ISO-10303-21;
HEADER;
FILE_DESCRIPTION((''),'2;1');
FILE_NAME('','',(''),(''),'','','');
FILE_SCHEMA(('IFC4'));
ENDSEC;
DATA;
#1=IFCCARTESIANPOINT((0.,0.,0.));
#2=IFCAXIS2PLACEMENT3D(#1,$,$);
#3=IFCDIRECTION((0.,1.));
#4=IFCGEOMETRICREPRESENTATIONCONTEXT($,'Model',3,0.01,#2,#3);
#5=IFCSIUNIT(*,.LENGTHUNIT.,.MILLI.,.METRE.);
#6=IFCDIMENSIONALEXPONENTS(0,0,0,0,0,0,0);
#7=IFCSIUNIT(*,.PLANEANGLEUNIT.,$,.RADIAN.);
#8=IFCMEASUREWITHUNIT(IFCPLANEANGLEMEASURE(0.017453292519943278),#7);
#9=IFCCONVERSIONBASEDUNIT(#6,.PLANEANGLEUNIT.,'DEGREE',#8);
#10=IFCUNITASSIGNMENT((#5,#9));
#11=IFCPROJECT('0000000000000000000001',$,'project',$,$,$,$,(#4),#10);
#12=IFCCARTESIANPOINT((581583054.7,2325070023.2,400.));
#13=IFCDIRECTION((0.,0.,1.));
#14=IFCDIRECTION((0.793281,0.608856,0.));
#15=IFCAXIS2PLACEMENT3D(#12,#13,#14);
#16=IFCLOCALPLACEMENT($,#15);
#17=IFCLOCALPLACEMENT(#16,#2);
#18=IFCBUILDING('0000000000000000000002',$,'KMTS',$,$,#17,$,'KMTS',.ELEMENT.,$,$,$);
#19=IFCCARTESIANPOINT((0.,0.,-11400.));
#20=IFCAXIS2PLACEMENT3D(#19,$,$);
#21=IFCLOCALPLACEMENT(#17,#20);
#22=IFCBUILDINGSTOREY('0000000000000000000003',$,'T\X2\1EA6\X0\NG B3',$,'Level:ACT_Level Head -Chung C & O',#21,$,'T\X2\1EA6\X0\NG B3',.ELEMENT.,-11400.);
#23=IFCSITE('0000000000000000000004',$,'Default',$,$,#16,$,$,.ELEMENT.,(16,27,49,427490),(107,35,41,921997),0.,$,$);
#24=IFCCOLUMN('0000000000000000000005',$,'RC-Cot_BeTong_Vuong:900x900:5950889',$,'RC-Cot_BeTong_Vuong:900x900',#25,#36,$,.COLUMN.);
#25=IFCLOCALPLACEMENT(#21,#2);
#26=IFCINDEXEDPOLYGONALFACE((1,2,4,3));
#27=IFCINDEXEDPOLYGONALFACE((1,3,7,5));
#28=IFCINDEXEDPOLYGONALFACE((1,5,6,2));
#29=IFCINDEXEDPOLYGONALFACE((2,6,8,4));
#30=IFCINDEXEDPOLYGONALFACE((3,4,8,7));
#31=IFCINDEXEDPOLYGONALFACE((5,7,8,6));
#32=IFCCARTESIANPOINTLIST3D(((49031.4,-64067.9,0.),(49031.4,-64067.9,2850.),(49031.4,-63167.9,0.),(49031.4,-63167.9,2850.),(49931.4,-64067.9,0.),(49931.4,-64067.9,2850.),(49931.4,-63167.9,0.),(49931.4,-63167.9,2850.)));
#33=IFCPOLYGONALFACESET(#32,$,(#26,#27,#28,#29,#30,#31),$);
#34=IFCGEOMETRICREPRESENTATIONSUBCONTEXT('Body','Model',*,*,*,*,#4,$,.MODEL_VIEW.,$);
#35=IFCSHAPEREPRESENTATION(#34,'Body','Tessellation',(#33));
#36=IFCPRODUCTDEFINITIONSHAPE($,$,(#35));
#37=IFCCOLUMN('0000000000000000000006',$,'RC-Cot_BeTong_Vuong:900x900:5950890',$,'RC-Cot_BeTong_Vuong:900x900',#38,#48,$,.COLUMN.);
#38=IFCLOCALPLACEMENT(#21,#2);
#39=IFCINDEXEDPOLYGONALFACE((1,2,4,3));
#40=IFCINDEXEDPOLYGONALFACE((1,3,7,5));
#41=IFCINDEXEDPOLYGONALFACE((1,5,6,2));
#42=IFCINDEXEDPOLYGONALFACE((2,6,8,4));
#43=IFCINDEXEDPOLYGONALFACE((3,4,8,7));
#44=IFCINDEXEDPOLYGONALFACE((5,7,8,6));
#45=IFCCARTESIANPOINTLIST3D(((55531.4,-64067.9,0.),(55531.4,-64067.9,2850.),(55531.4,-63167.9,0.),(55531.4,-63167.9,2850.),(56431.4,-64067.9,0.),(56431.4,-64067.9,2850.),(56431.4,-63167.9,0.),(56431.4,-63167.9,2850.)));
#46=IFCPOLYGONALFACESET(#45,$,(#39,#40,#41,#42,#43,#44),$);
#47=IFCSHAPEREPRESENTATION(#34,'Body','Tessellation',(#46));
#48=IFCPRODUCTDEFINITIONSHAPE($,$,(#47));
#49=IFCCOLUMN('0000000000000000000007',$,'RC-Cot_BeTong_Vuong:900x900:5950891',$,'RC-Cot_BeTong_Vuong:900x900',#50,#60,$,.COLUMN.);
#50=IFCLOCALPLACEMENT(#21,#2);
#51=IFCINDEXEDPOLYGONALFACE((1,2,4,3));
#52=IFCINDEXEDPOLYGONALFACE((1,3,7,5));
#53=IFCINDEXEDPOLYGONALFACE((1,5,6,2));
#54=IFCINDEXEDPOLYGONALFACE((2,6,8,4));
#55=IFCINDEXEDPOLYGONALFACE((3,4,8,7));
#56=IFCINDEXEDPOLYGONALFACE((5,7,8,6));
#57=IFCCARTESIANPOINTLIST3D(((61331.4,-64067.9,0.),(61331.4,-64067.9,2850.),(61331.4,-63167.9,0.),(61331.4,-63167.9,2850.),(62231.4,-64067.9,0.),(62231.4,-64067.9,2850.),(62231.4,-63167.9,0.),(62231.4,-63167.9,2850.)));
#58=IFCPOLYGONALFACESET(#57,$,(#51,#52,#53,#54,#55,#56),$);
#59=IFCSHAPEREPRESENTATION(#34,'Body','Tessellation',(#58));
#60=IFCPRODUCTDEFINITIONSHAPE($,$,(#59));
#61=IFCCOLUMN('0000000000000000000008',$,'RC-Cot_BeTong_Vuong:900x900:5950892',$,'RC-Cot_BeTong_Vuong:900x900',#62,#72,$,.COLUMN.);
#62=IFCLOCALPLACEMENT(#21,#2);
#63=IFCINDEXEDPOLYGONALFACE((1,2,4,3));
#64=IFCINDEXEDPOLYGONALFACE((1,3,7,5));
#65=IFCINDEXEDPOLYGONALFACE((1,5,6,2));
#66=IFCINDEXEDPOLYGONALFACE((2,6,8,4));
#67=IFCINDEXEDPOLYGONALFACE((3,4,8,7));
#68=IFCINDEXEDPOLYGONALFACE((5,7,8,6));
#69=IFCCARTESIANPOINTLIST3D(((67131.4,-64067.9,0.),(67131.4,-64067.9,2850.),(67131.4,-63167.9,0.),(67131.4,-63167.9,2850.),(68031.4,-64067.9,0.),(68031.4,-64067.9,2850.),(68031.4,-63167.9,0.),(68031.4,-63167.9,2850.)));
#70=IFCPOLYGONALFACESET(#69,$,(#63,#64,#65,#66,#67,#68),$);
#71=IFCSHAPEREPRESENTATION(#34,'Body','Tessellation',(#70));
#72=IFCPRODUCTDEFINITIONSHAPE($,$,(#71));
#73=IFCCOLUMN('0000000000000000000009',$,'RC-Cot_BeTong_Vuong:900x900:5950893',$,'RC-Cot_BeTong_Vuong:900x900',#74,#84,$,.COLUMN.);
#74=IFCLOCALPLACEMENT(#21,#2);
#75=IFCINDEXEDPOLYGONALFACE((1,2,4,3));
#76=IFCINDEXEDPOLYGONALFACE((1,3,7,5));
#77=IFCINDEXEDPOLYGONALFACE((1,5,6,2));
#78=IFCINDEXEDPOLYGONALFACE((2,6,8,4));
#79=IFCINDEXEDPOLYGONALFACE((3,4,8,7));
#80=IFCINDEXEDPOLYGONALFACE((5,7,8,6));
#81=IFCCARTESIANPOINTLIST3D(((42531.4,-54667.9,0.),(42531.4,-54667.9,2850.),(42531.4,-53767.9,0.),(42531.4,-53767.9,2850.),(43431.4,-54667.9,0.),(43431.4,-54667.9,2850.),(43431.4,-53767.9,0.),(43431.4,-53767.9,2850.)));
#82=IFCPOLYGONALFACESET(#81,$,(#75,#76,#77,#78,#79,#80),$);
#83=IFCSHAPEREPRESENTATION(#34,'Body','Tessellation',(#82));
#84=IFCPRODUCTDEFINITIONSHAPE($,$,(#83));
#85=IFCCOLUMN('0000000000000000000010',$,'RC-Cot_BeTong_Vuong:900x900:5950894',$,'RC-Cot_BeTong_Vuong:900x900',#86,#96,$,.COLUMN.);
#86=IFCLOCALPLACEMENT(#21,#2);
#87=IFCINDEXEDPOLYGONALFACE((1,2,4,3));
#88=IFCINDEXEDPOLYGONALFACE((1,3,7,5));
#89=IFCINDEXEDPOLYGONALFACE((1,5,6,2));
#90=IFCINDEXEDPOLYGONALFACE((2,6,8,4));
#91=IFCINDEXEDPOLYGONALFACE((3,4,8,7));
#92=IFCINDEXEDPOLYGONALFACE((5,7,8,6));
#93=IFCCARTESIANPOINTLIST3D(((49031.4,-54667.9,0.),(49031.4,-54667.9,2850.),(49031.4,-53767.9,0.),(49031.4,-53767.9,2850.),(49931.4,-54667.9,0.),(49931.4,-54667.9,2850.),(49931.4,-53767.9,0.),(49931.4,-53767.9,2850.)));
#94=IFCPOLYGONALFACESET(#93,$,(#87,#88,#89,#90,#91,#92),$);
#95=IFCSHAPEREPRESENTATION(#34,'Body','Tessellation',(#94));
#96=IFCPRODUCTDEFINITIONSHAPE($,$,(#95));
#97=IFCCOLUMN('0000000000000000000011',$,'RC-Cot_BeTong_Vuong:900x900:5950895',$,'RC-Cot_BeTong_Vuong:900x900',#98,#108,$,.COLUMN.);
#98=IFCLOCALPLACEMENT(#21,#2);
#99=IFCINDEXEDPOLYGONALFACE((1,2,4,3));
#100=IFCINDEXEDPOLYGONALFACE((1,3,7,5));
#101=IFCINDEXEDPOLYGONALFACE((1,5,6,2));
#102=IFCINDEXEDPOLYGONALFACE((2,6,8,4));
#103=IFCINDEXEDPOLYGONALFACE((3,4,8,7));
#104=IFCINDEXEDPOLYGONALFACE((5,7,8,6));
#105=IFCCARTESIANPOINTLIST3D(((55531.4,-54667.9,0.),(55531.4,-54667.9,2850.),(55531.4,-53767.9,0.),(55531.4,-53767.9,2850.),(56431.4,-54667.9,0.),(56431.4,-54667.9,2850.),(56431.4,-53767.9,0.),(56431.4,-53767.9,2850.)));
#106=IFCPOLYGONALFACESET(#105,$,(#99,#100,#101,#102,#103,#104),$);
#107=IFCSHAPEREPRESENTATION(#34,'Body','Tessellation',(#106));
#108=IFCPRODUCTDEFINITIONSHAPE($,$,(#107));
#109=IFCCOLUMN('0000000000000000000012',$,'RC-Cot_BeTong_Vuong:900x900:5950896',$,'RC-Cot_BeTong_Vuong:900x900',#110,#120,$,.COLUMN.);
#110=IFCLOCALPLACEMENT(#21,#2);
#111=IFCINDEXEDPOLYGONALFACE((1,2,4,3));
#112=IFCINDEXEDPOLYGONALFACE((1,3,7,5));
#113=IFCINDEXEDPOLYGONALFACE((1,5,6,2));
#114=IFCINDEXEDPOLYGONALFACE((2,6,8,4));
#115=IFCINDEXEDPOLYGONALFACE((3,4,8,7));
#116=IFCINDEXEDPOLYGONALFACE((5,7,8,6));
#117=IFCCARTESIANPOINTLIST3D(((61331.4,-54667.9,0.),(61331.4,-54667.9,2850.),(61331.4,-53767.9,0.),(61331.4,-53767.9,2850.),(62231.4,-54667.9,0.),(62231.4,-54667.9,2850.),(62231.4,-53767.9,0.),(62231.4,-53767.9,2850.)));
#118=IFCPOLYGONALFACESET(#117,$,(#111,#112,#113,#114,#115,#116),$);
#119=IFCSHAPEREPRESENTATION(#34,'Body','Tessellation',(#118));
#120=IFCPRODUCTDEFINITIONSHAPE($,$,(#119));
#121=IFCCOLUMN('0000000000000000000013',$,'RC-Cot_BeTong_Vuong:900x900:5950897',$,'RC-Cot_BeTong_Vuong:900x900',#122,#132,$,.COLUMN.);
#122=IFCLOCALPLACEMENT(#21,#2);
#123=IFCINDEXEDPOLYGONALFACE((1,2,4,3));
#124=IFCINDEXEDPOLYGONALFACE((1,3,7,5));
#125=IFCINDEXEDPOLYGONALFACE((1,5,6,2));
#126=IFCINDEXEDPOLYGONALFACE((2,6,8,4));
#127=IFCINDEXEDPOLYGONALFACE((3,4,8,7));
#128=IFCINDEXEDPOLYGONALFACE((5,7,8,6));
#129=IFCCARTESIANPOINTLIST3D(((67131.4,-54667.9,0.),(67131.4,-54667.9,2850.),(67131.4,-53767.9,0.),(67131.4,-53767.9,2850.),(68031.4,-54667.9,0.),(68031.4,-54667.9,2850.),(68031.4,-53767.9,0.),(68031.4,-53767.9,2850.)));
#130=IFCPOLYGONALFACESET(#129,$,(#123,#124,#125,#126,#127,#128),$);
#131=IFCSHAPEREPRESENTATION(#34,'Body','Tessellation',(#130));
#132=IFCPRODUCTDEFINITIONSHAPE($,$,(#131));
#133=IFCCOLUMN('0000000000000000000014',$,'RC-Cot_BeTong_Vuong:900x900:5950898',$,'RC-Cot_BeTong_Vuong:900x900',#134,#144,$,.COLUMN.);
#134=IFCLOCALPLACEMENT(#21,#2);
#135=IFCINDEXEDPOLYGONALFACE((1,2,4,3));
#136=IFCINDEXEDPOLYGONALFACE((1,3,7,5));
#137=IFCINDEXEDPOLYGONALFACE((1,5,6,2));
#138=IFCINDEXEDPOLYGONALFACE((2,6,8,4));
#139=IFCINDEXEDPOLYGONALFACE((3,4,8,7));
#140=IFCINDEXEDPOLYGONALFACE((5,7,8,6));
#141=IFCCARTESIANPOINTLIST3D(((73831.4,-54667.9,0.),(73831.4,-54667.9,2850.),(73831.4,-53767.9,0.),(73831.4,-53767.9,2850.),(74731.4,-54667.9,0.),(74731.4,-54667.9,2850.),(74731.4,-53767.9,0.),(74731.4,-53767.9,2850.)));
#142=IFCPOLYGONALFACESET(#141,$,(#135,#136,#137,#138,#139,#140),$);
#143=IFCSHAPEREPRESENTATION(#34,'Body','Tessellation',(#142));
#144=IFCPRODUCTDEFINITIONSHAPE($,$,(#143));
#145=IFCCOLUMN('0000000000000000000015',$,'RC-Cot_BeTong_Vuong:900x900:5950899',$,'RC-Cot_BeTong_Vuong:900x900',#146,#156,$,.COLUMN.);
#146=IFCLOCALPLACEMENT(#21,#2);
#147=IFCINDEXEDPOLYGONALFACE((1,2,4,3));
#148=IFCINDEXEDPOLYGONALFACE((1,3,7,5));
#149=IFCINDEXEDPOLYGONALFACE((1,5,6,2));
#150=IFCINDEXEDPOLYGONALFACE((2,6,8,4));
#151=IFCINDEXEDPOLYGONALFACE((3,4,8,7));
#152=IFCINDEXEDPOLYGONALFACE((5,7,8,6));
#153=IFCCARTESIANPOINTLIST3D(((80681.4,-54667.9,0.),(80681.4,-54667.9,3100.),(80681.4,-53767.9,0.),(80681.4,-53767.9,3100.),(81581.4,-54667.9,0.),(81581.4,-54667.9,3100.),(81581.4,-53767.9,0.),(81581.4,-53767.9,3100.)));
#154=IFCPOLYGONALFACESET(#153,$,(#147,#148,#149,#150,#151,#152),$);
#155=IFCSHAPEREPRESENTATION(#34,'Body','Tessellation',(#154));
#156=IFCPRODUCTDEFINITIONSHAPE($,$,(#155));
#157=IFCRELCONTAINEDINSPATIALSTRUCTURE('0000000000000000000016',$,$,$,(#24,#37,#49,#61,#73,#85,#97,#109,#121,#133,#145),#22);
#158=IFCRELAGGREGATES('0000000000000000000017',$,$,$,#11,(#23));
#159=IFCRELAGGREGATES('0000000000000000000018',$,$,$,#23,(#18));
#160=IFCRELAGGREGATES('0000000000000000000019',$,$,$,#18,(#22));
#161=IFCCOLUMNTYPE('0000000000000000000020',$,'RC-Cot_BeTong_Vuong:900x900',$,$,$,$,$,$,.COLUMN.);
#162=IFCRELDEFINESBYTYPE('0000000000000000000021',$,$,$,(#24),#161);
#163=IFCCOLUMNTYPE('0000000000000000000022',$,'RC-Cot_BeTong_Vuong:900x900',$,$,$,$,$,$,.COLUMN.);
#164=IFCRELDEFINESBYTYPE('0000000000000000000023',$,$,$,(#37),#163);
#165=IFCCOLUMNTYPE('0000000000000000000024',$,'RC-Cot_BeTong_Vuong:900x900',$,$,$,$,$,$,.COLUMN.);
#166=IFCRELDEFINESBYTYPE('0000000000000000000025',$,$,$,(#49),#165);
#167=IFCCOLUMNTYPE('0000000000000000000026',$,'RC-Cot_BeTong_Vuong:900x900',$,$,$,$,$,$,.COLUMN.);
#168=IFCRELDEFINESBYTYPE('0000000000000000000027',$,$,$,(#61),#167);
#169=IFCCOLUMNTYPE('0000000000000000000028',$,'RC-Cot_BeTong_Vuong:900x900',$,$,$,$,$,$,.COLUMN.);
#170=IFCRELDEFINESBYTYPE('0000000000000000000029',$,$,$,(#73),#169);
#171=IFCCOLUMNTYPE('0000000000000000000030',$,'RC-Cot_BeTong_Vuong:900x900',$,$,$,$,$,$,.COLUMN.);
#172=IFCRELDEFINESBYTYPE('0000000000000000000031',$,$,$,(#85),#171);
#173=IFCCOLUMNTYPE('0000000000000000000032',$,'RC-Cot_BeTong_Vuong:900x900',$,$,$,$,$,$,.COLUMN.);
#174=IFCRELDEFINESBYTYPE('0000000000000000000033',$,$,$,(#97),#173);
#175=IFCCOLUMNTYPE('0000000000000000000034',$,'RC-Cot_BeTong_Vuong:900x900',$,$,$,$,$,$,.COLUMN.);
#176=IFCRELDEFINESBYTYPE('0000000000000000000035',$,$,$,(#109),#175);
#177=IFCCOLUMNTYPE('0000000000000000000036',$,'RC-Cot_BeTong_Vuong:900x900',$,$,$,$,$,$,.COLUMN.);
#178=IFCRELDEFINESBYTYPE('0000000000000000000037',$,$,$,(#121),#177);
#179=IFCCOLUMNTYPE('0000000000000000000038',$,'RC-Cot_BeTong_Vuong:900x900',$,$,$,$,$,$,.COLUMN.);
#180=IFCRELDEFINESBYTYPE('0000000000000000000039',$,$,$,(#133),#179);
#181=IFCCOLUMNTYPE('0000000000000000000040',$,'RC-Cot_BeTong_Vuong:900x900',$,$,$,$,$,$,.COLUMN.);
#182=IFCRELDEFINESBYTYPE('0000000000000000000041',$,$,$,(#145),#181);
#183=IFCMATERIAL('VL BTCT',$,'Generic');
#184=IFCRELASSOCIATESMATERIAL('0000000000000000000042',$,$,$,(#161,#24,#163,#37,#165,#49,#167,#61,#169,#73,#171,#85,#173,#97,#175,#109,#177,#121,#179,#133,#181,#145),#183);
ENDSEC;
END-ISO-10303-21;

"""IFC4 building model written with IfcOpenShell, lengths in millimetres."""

from ifc_helpers import new_model, entity, si_unit, converted_unit, direction, frame, origin, place, context, subcontext, project, spatial, indexed_curve, outline, extrude, source, transform, mapped, material, type_object, type_shapes, element, save


model = new_model("IFC4")

# Units and contexts
model_context = context("Model", 3, precision=0.01, world=origin(), true_north=direction((0.0, 1.0)))
body_context = subcontext(model_context, "Body", "Model", "MODEL_VIEW")
ifc_project = project(units=[si_unit("LENGTHUNIT", "METRE", prefix="MILLI"), converted_unit("PLANEANGLEUNIT", "DEGREE", entity("IfcPlaneAngleMeasure", 0.017453292519943278), si_unit("PLANEANGLEUNIT", "RADIAN"), dimensions=[0, 0, 0, 0, 0, 0, 0])], contexts=[model_context])

# Site, building, storey
site_placement = place(None, frame((581583054.7, 2325070023.2, 400.0), z_axis=(0.0, 0.0, 1.0), x_axis=(0.793281, 0.608856, 0.0)))
site = spatial("IfcSite", under=ifc_project, at=site_placement, Name="Default", CompositionType="ELEMENT", RefLatitude=(16, 27, 49, 427490), RefLongitude=(107, 35, 41, 921997), RefElevation=0.0)
building_placement = place(site_placement, origin())
building = spatial("IfcBuilding", under=site, at=building_placement, Name="KMTS", LongName="KMTS", CompositionType="ELEMENT")
storey_placement = place(building_placement, frame((0.0, 0.0, -11400.0)))
storey = spatial("IfcBuildingStorey", under=building, at=storey_placement, Name="TẦNG B3", ObjectType="Level:ACT_Level Head -Chung C & O", LongName="TẦNG B3", CompositionType="ELEMENT", Elevation=-11400.0)

# Columns
ifc_material = material(Name="VL BTCT", Category="Generic")
column_type_1 = type_object("IfcColumnType", Name="RC-Cot_BeTong_Vuong:900x900", PredefinedType="COLUMN", material=ifc_material)
shared_shape_1 = source(origin(), body_context, "Body", "SweptSolid", [
    extrude(outline(indexed_curve([(-450.0, -450.0), (450.0, -450.0), (450.0, 450.0), (-450.0, 450.0), (-450.0, -450.0)], self_intersect=False)), frame((49481.4, -63617.9, -11400.0), z_axis=(0.0, 0.0, 1.0), x_axis=(-1.0, 0.0, 0.0)), (0.0, 0.0, 1.0), 2850.0),
])
type_shapes(column_type_1, [shared_shape_1])
column_1_placement = place(storey_placement, frame((0.0, 0.0, 11400.0)))
element("IfcColumn", 1, at=column_1_placement, inside=storey, type_object=column_type_1, material=ifc_material, Name="RC-Cot_BeTong_Vuong:900x900:5950889", ObjectType="RC-Cot_BeTong_Vuong:900x900", PredefinedType="COLUMN", context=body_context, shape_type="MappedRepresentation", body=[
    mapped(shared_shape_1, transform((0.0, 0.0, 0.0), scale=1.0)),
])
column_type_2 = type_object("IfcColumnType", Name="RC-Cot_BeTong_Vuong:900x900", PredefinedType="COLUMN", material=ifc_material)
shared_shape_2 = source(origin(), body_context, "Body", "SweptSolid", [
    extrude(outline(indexed_curve([(-450.0, -450.0), (450.0, -450.0), (450.0, 450.0), (-450.0, 450.0), (-450.0, -450.0)], self_intersect=False)), frame((55981.4, -63617.9, -11400.0), z_axis=(0.0, 0.0, 1.0), x_axis=(-1.0, 0.0, 0.0)), (0.0, 0.0, 1.0), 2850.0),
])
type_shapes(column_type_2, [shared_shape_2])
column_2_placement = place(storey_placement, frame((0.0, 0.0, 11400.0)))
element("IfcColumn", 2, at=column_2_placement, inside=storey, type_object=column_type_2, material=ifc_material, Name="RC-Cot_BeTong_Vuong:900x900:5950890", ObjectType="RC-Cot_BeTong_Vuong:900x900", PredefinedType="COLUMN", context=body_context, shape_type="MappedRepresentation", body=[
    mapped(shared_shape_2, transform((0.0, 0.0, 0.0), scale=1.0)),
])
column_type_3 = type_object("IfcColumnType", Name="RC-Cot_BeTong_Vuong:900x900", PredefinedType="COLUMN", material=ifc_material)
shared_shape_3 = source(origin(), body_context, "Body", "SweptSolid", [
    extrude(outline(indexed_curve([(-450.0, -450.0), (450.0, -450.0), (450.0, 450.0), (-450.0, 450.0), (-450.0, -450.0)], self_intersect=False)), frame((61781.4, -63617.9, -11400.0), z_axis=(0.0, 0.0, 1.0), x_axis=(-1.0, 0.0, 0.0)), (0.0, 0.0, 1.0), 2850.0),
])
type_shapes(column_type_3, [shared_shape_3])
column_3_placement = place(storey_placement, frame((0.0, 0.0, 11400.0)))
element("IfcColumn", 3, at=column_3_placement, inside=storey, type_object=column_type_3, material=ifc_material, Name="RC-Cot_BeTong_Vuong:900x900:5950891", ObjectType="RC-Cot_BeTong_Vuong:900x900", PredefinedType="COLUMN", context=body_context, shape_type="MappedRepresentation", body=[
    mapped(shared_shape_3, transform((0.0, 0.0, 0.0), scale=1.0)),
])
column_type_4 = type_object("IfcColumnType", Name="RC-Cot_BeTong_Vuong:900x900", PredefinedType="COLUMN", material=ifc_material)
shared_shape_4 = source(origin(), body_context, "Body", "SweptSolid", [
    extrude(outline(indexed_curve([(-450.0, -450.0), (450.0, -450.0), (450.0, 450.0), (-450.0, 450.0), (-450.0, -450.0)], self_intersect=False)), frame((67581.4, -63617.9, -11400.0), z_axis=(0.0, 0.0, 1.0), x_axis=(-1.0, 0.0, 0.0)), (0.0, 0.0, 1.0), 2850.0),
])
type_shapes(column_type_4, [shared_shape_4])
column_4_placement = place(storey_placement, frame((0.0, 0.0, 11400.0)))
element("IfcColumn", 4, at=column_4_placement, inside=storey, type_object=column_type_4, material=ifc_material, Name="RC-Cot_BeTong_Vuong:900x900:5950892", ObjectType="RC-Cot_BeTong_Vuong:900x900", PredefinedType="COLUMN", context=body_context, shape_type="MappedRepresentation", body=[
    mapped(shared_shape_4, transform((0.0, 0.0, 0.0), scale=1.0)),
])
column_type_5 = type_object("IfcColumnType", Name="RC-Cot_BeTong_Vuong:900x900", PredefinedType="COLUMN", material=ifc_material)
shared_shape_5 = source(origin(), body_context, "Body", "SweptSolid", [
    extrude(outline(indexed_curve([(-450.0, -450.0), (450.0, -450.0), (450.0, 450.0), (-450.0, 450.0), (-450.0, -450.0)], self_intersect=False)), frame((42981.4, -54217.9, -11400.0), z_axis=(0.0, 0.0, 1.0), x_axis=(-1.0, 0.0, 0.0)), (0.0, 0.0, 1.0), 2850.0),
])
type_shapes(column_type_5, [shared_shape_5])
column_5_placement = place(storey_placement, frame((0.0, 0.0, 11400.0)))
element("IfcColumn", 5, at=column_5_placement, inside=storey, type_object=column_type_5, material=ifc_material, Name="RC-Cot_BeTong_Vuong:900x900:5950893", ObjectType="RC-Cot_BeTong_Vuong:900x900", PredefinedType="COLUMN", context=body_context, shape_type="MappedRepresentation", body=[
    mapped(shared_shape_5, transform((0.0, 0.0, 0.0), scale=1.0)),
])
column_type_6 = type_object("IfcColumnType", Name="RC-Cot_BeTong_Vuong:900x900", PredefinedType="COLUMN", material=ifc_material)
shared_shape_6 = source(origin(), body_context, "Body", "SweptSolid", [
    extrude(outline(indexed_curve([(-450.0, -450.0), (450.0, -450.0), (450.0, 450.0), (-450.0, 450.0), (-450.0, -450.0)], self_intersect=False)), frame((49481.4, -54217.9, -11400.0), z_axis=(0.0, 0.0, 1.0), x_axis=(-1.0, 0.0, 0.0)), (0.0, 0.0, 1.0), 2850.0),
])
type_shapes(column_type_6, [shared_shape_6])
column_6_placement = place(storey_placement, frame((0.0, 0.0, 11400.0)))
element("IfcColumn", 6, at=column_6_placement, inside=storey, type_object=column_type_6, material=ifc_material, Name="RC-Cot_BeTong_Vuong:900x900:5950894", ObjectType="RC-Cot_BeTong_Vuong:900x900", PredefinedType="COLUMN", context=body_context, shape_type="MappedRepresentation", body=[
    mapped(shared_shape_6, transform((0.0, 0.0, 0.0), scale=1.0)),
])
column_type_7 = type_object("IfcColumnType", Name="RC-Cot_BeTong_Vuong:900x900", PredefinedType="COLUMN", material=ifc_material)
shared_shape_7 = source(origin(), body_context, "Body", "SweptSolid", [
    extrude(outline(indexed_curve([(-450.0, -450.0), (450.0, -450.0), (450.0, 450.0), (-450.0, 450.0), (-450.0, -450.0)], self_intersect=False)), frame((55981.4, -54217.9, -11400.0), z_axis=(0.0, 0.0, 1.0), x_axis=(-1.0, 0.0, 0.0)), (0.0, 0.0, 1.0), 2850.0),
])
type_shapes(column_type_7, [shared_shape_7])
column_7_placement = place(storey_placement, frame((0.0, 0.0, 11400.0)))
element("IfcColumn", 7, at=column_7_placement, inside=storey, type_object=column_type_7, material=ifc_material, Name="RC-Cot_BeTong_Vuong:900x900:5950895", ObjectType="RC-Cot_BeTong_Vuong:900x900", PredefinedType="COLUMN", context=body_context, shape_type="MappedRepresentation", body=[
    mapped(shared_shape_7, transform((0.0, 0.0, 0.0), scale=1.0)),
])
column_type_8 = type_object("IfcColumnType", Name="RC-Cot_BeTong_Vuong:900x900", PredefinedType="COLUMN", material=ifc_material)
shared_shape_8 = source(origin(), body_context, "Body", "SweptSolid", [
    extrude(outline(indexed_curve([(-450.0, -450.0), (450.0, -450.0), (450.0, 450.0), (-450.0, 450.0), (-450.0, -450.0)], self_intersect=False)), frame((61781.4, -54217.9, -11400.0), z_axis=(0.0, 0.0, 1.0), x_axis=(-1.0, 0.0, 0.0)), (0.0, 0.0, 1.0), 2850.0),
])
type_shapes(column_type_8, [shared_shape_8])
column_8_placement = place(storey_placement, frame((0.0, 0.0, 11400.0)))
element("IfcColumn", 8, at=column_8_placement, inside=storey, type_object=column_type_8, material=ifc_material, Name="RC-Cot_BeTong_Vuong:900x900:5950896", ObjectType="RC-Cot_BeTong_Vuong:900x900", PredefinedType="COLUMN", context=body_context, shape_type="MappedRepresentation", body=[
    mapped(shared_shape_8, transform((0.0, 0.0, 0.0), scale=1.0)),
])
column_type_9 = type_object("IfcColumnType", Name="RC-Cot_BeTong_Vuong:900x900", PredefinedType="COLUMN", material=ifc_material)
shared_shape_9 = source(origin(), body_context, "Body", "SweptSolid", [
    extrude(outline(indexed_curve([(-450.0, -450.0), (450.0, -450.0), (450.0, 450.0), (-450.0, 450.0), (-450.0, -450.0)], self_intersect=False)), frame((67581.4, -54217.9, -11400.0), z_axis=(0.0, 0.0, 1.0), x_axis=(-1.0, 0.0, 0.0)), (0.0, 0.0, 1.0), 2850.0),
])
type_shapes(column_type_9, [shared_shape_9])
column_9_placement = place(storey_placement, frame((0.0, 0.0, 11400.0)))
element("IfcColumn", 9, at=column_9_placement, inside=storey, type_object=column_type_9, material=ifc_material, Name="RC-Cot_BeTong_Vuong:900x900:5950897", ObjectType="RC-Cot_BeTong_Vuong:900x900", PredefinedType="COLUMN", context=body_context, shape_type="MappedRepresentation", body=[
    mapped(shared_shape_9, transform((0.0, 0.0, 0.0), scale=1.0)),
])
column_type_10 = type_object("IfcColumnType", Name="RC-Cot_BeTong_Vuong:900x900", PredefinedType="COLUMN", material=ifc_material)
shared_shape_10 = source(origin(), body_context, "Body", "SweptSolid", [
    extrude(outline(indexed_curve([(-450.0, -450.0), (450.0, -450.0), (450.0, 450.0), (-450.0, 450.0), (-450.0, -450.0)], self_intersect=False)), frame((74281.4, -54217.9, -11400.0), z_axis=(0.0, 0.0, 1.0), x_axis=(-1.0, 0.0, 0.0)), (0.0, 0.0, 1.0), 2850.0),
])
type_shapes(column_type_10, [shared_shape_10])
column_10_placement = place(storey_placement, frame((0.0, 0.0, 11400.0)))
element("IfcColumn", 10, at=column_10_placement, inside=storey, type_object=column_type_10, material=ifc_material, Name="RC-Cot_BeTong_Vuong:900x900:5950898", ObjectType="RC-Cot_BeTong_Vuong:900x900", PredefinedType="COLUMN", context=body_context, shape_type="MappedRepresentation", body=[
    mapped(shared_shape_10, transform((0.0, 0.0, 0.0), scale=1.0)),
])
column_type_11 = type_object("IfcColumnType", Name="RC-Cot_BeTong_Vuong:900x900", PredefinedType="COLUMN", material=ifc_material)
shared_shape_11 = source(origin(), body_context, "Body", "SweptSolid", [
    extrude(outline(indexed_curve([(-450.0, -450.0), (450.0, -450.0), (450.0, 450.0), (-450.0, 450.0), (-450.0, -450.0)], self_intersect=False)), frame((81131.4, -54217.9, -11400.0), z_axis=(0.0, 0.0, 1.0), x_axis=(-1.0, 0.0, 0.0)), (0.0, 0.0, 1.0), 3100.0),
])
type_shapes(column_type_11, [shared_shape_11])
column_11_placement = place(storey_placement, frame((0.0, 0.0, 11400.0)))
element("IfcColumn", 11, at=column_11_placement, inside=storey, type_object=column_type_11, material=ifc_material, Name="RC-Cot_BeTong_Vuong:900x900:5950899", ObjectType="RC-Cot_BeTong_Vuong:900x900", PredefinedType="COLUMN", context=body_context, shape_type="MappedRepresentation", body=[
    mapped(shared_shape_11, transform((0.0, 0.0, 0.0), scale=1.0)),
])

save(model, "model.ifc")
